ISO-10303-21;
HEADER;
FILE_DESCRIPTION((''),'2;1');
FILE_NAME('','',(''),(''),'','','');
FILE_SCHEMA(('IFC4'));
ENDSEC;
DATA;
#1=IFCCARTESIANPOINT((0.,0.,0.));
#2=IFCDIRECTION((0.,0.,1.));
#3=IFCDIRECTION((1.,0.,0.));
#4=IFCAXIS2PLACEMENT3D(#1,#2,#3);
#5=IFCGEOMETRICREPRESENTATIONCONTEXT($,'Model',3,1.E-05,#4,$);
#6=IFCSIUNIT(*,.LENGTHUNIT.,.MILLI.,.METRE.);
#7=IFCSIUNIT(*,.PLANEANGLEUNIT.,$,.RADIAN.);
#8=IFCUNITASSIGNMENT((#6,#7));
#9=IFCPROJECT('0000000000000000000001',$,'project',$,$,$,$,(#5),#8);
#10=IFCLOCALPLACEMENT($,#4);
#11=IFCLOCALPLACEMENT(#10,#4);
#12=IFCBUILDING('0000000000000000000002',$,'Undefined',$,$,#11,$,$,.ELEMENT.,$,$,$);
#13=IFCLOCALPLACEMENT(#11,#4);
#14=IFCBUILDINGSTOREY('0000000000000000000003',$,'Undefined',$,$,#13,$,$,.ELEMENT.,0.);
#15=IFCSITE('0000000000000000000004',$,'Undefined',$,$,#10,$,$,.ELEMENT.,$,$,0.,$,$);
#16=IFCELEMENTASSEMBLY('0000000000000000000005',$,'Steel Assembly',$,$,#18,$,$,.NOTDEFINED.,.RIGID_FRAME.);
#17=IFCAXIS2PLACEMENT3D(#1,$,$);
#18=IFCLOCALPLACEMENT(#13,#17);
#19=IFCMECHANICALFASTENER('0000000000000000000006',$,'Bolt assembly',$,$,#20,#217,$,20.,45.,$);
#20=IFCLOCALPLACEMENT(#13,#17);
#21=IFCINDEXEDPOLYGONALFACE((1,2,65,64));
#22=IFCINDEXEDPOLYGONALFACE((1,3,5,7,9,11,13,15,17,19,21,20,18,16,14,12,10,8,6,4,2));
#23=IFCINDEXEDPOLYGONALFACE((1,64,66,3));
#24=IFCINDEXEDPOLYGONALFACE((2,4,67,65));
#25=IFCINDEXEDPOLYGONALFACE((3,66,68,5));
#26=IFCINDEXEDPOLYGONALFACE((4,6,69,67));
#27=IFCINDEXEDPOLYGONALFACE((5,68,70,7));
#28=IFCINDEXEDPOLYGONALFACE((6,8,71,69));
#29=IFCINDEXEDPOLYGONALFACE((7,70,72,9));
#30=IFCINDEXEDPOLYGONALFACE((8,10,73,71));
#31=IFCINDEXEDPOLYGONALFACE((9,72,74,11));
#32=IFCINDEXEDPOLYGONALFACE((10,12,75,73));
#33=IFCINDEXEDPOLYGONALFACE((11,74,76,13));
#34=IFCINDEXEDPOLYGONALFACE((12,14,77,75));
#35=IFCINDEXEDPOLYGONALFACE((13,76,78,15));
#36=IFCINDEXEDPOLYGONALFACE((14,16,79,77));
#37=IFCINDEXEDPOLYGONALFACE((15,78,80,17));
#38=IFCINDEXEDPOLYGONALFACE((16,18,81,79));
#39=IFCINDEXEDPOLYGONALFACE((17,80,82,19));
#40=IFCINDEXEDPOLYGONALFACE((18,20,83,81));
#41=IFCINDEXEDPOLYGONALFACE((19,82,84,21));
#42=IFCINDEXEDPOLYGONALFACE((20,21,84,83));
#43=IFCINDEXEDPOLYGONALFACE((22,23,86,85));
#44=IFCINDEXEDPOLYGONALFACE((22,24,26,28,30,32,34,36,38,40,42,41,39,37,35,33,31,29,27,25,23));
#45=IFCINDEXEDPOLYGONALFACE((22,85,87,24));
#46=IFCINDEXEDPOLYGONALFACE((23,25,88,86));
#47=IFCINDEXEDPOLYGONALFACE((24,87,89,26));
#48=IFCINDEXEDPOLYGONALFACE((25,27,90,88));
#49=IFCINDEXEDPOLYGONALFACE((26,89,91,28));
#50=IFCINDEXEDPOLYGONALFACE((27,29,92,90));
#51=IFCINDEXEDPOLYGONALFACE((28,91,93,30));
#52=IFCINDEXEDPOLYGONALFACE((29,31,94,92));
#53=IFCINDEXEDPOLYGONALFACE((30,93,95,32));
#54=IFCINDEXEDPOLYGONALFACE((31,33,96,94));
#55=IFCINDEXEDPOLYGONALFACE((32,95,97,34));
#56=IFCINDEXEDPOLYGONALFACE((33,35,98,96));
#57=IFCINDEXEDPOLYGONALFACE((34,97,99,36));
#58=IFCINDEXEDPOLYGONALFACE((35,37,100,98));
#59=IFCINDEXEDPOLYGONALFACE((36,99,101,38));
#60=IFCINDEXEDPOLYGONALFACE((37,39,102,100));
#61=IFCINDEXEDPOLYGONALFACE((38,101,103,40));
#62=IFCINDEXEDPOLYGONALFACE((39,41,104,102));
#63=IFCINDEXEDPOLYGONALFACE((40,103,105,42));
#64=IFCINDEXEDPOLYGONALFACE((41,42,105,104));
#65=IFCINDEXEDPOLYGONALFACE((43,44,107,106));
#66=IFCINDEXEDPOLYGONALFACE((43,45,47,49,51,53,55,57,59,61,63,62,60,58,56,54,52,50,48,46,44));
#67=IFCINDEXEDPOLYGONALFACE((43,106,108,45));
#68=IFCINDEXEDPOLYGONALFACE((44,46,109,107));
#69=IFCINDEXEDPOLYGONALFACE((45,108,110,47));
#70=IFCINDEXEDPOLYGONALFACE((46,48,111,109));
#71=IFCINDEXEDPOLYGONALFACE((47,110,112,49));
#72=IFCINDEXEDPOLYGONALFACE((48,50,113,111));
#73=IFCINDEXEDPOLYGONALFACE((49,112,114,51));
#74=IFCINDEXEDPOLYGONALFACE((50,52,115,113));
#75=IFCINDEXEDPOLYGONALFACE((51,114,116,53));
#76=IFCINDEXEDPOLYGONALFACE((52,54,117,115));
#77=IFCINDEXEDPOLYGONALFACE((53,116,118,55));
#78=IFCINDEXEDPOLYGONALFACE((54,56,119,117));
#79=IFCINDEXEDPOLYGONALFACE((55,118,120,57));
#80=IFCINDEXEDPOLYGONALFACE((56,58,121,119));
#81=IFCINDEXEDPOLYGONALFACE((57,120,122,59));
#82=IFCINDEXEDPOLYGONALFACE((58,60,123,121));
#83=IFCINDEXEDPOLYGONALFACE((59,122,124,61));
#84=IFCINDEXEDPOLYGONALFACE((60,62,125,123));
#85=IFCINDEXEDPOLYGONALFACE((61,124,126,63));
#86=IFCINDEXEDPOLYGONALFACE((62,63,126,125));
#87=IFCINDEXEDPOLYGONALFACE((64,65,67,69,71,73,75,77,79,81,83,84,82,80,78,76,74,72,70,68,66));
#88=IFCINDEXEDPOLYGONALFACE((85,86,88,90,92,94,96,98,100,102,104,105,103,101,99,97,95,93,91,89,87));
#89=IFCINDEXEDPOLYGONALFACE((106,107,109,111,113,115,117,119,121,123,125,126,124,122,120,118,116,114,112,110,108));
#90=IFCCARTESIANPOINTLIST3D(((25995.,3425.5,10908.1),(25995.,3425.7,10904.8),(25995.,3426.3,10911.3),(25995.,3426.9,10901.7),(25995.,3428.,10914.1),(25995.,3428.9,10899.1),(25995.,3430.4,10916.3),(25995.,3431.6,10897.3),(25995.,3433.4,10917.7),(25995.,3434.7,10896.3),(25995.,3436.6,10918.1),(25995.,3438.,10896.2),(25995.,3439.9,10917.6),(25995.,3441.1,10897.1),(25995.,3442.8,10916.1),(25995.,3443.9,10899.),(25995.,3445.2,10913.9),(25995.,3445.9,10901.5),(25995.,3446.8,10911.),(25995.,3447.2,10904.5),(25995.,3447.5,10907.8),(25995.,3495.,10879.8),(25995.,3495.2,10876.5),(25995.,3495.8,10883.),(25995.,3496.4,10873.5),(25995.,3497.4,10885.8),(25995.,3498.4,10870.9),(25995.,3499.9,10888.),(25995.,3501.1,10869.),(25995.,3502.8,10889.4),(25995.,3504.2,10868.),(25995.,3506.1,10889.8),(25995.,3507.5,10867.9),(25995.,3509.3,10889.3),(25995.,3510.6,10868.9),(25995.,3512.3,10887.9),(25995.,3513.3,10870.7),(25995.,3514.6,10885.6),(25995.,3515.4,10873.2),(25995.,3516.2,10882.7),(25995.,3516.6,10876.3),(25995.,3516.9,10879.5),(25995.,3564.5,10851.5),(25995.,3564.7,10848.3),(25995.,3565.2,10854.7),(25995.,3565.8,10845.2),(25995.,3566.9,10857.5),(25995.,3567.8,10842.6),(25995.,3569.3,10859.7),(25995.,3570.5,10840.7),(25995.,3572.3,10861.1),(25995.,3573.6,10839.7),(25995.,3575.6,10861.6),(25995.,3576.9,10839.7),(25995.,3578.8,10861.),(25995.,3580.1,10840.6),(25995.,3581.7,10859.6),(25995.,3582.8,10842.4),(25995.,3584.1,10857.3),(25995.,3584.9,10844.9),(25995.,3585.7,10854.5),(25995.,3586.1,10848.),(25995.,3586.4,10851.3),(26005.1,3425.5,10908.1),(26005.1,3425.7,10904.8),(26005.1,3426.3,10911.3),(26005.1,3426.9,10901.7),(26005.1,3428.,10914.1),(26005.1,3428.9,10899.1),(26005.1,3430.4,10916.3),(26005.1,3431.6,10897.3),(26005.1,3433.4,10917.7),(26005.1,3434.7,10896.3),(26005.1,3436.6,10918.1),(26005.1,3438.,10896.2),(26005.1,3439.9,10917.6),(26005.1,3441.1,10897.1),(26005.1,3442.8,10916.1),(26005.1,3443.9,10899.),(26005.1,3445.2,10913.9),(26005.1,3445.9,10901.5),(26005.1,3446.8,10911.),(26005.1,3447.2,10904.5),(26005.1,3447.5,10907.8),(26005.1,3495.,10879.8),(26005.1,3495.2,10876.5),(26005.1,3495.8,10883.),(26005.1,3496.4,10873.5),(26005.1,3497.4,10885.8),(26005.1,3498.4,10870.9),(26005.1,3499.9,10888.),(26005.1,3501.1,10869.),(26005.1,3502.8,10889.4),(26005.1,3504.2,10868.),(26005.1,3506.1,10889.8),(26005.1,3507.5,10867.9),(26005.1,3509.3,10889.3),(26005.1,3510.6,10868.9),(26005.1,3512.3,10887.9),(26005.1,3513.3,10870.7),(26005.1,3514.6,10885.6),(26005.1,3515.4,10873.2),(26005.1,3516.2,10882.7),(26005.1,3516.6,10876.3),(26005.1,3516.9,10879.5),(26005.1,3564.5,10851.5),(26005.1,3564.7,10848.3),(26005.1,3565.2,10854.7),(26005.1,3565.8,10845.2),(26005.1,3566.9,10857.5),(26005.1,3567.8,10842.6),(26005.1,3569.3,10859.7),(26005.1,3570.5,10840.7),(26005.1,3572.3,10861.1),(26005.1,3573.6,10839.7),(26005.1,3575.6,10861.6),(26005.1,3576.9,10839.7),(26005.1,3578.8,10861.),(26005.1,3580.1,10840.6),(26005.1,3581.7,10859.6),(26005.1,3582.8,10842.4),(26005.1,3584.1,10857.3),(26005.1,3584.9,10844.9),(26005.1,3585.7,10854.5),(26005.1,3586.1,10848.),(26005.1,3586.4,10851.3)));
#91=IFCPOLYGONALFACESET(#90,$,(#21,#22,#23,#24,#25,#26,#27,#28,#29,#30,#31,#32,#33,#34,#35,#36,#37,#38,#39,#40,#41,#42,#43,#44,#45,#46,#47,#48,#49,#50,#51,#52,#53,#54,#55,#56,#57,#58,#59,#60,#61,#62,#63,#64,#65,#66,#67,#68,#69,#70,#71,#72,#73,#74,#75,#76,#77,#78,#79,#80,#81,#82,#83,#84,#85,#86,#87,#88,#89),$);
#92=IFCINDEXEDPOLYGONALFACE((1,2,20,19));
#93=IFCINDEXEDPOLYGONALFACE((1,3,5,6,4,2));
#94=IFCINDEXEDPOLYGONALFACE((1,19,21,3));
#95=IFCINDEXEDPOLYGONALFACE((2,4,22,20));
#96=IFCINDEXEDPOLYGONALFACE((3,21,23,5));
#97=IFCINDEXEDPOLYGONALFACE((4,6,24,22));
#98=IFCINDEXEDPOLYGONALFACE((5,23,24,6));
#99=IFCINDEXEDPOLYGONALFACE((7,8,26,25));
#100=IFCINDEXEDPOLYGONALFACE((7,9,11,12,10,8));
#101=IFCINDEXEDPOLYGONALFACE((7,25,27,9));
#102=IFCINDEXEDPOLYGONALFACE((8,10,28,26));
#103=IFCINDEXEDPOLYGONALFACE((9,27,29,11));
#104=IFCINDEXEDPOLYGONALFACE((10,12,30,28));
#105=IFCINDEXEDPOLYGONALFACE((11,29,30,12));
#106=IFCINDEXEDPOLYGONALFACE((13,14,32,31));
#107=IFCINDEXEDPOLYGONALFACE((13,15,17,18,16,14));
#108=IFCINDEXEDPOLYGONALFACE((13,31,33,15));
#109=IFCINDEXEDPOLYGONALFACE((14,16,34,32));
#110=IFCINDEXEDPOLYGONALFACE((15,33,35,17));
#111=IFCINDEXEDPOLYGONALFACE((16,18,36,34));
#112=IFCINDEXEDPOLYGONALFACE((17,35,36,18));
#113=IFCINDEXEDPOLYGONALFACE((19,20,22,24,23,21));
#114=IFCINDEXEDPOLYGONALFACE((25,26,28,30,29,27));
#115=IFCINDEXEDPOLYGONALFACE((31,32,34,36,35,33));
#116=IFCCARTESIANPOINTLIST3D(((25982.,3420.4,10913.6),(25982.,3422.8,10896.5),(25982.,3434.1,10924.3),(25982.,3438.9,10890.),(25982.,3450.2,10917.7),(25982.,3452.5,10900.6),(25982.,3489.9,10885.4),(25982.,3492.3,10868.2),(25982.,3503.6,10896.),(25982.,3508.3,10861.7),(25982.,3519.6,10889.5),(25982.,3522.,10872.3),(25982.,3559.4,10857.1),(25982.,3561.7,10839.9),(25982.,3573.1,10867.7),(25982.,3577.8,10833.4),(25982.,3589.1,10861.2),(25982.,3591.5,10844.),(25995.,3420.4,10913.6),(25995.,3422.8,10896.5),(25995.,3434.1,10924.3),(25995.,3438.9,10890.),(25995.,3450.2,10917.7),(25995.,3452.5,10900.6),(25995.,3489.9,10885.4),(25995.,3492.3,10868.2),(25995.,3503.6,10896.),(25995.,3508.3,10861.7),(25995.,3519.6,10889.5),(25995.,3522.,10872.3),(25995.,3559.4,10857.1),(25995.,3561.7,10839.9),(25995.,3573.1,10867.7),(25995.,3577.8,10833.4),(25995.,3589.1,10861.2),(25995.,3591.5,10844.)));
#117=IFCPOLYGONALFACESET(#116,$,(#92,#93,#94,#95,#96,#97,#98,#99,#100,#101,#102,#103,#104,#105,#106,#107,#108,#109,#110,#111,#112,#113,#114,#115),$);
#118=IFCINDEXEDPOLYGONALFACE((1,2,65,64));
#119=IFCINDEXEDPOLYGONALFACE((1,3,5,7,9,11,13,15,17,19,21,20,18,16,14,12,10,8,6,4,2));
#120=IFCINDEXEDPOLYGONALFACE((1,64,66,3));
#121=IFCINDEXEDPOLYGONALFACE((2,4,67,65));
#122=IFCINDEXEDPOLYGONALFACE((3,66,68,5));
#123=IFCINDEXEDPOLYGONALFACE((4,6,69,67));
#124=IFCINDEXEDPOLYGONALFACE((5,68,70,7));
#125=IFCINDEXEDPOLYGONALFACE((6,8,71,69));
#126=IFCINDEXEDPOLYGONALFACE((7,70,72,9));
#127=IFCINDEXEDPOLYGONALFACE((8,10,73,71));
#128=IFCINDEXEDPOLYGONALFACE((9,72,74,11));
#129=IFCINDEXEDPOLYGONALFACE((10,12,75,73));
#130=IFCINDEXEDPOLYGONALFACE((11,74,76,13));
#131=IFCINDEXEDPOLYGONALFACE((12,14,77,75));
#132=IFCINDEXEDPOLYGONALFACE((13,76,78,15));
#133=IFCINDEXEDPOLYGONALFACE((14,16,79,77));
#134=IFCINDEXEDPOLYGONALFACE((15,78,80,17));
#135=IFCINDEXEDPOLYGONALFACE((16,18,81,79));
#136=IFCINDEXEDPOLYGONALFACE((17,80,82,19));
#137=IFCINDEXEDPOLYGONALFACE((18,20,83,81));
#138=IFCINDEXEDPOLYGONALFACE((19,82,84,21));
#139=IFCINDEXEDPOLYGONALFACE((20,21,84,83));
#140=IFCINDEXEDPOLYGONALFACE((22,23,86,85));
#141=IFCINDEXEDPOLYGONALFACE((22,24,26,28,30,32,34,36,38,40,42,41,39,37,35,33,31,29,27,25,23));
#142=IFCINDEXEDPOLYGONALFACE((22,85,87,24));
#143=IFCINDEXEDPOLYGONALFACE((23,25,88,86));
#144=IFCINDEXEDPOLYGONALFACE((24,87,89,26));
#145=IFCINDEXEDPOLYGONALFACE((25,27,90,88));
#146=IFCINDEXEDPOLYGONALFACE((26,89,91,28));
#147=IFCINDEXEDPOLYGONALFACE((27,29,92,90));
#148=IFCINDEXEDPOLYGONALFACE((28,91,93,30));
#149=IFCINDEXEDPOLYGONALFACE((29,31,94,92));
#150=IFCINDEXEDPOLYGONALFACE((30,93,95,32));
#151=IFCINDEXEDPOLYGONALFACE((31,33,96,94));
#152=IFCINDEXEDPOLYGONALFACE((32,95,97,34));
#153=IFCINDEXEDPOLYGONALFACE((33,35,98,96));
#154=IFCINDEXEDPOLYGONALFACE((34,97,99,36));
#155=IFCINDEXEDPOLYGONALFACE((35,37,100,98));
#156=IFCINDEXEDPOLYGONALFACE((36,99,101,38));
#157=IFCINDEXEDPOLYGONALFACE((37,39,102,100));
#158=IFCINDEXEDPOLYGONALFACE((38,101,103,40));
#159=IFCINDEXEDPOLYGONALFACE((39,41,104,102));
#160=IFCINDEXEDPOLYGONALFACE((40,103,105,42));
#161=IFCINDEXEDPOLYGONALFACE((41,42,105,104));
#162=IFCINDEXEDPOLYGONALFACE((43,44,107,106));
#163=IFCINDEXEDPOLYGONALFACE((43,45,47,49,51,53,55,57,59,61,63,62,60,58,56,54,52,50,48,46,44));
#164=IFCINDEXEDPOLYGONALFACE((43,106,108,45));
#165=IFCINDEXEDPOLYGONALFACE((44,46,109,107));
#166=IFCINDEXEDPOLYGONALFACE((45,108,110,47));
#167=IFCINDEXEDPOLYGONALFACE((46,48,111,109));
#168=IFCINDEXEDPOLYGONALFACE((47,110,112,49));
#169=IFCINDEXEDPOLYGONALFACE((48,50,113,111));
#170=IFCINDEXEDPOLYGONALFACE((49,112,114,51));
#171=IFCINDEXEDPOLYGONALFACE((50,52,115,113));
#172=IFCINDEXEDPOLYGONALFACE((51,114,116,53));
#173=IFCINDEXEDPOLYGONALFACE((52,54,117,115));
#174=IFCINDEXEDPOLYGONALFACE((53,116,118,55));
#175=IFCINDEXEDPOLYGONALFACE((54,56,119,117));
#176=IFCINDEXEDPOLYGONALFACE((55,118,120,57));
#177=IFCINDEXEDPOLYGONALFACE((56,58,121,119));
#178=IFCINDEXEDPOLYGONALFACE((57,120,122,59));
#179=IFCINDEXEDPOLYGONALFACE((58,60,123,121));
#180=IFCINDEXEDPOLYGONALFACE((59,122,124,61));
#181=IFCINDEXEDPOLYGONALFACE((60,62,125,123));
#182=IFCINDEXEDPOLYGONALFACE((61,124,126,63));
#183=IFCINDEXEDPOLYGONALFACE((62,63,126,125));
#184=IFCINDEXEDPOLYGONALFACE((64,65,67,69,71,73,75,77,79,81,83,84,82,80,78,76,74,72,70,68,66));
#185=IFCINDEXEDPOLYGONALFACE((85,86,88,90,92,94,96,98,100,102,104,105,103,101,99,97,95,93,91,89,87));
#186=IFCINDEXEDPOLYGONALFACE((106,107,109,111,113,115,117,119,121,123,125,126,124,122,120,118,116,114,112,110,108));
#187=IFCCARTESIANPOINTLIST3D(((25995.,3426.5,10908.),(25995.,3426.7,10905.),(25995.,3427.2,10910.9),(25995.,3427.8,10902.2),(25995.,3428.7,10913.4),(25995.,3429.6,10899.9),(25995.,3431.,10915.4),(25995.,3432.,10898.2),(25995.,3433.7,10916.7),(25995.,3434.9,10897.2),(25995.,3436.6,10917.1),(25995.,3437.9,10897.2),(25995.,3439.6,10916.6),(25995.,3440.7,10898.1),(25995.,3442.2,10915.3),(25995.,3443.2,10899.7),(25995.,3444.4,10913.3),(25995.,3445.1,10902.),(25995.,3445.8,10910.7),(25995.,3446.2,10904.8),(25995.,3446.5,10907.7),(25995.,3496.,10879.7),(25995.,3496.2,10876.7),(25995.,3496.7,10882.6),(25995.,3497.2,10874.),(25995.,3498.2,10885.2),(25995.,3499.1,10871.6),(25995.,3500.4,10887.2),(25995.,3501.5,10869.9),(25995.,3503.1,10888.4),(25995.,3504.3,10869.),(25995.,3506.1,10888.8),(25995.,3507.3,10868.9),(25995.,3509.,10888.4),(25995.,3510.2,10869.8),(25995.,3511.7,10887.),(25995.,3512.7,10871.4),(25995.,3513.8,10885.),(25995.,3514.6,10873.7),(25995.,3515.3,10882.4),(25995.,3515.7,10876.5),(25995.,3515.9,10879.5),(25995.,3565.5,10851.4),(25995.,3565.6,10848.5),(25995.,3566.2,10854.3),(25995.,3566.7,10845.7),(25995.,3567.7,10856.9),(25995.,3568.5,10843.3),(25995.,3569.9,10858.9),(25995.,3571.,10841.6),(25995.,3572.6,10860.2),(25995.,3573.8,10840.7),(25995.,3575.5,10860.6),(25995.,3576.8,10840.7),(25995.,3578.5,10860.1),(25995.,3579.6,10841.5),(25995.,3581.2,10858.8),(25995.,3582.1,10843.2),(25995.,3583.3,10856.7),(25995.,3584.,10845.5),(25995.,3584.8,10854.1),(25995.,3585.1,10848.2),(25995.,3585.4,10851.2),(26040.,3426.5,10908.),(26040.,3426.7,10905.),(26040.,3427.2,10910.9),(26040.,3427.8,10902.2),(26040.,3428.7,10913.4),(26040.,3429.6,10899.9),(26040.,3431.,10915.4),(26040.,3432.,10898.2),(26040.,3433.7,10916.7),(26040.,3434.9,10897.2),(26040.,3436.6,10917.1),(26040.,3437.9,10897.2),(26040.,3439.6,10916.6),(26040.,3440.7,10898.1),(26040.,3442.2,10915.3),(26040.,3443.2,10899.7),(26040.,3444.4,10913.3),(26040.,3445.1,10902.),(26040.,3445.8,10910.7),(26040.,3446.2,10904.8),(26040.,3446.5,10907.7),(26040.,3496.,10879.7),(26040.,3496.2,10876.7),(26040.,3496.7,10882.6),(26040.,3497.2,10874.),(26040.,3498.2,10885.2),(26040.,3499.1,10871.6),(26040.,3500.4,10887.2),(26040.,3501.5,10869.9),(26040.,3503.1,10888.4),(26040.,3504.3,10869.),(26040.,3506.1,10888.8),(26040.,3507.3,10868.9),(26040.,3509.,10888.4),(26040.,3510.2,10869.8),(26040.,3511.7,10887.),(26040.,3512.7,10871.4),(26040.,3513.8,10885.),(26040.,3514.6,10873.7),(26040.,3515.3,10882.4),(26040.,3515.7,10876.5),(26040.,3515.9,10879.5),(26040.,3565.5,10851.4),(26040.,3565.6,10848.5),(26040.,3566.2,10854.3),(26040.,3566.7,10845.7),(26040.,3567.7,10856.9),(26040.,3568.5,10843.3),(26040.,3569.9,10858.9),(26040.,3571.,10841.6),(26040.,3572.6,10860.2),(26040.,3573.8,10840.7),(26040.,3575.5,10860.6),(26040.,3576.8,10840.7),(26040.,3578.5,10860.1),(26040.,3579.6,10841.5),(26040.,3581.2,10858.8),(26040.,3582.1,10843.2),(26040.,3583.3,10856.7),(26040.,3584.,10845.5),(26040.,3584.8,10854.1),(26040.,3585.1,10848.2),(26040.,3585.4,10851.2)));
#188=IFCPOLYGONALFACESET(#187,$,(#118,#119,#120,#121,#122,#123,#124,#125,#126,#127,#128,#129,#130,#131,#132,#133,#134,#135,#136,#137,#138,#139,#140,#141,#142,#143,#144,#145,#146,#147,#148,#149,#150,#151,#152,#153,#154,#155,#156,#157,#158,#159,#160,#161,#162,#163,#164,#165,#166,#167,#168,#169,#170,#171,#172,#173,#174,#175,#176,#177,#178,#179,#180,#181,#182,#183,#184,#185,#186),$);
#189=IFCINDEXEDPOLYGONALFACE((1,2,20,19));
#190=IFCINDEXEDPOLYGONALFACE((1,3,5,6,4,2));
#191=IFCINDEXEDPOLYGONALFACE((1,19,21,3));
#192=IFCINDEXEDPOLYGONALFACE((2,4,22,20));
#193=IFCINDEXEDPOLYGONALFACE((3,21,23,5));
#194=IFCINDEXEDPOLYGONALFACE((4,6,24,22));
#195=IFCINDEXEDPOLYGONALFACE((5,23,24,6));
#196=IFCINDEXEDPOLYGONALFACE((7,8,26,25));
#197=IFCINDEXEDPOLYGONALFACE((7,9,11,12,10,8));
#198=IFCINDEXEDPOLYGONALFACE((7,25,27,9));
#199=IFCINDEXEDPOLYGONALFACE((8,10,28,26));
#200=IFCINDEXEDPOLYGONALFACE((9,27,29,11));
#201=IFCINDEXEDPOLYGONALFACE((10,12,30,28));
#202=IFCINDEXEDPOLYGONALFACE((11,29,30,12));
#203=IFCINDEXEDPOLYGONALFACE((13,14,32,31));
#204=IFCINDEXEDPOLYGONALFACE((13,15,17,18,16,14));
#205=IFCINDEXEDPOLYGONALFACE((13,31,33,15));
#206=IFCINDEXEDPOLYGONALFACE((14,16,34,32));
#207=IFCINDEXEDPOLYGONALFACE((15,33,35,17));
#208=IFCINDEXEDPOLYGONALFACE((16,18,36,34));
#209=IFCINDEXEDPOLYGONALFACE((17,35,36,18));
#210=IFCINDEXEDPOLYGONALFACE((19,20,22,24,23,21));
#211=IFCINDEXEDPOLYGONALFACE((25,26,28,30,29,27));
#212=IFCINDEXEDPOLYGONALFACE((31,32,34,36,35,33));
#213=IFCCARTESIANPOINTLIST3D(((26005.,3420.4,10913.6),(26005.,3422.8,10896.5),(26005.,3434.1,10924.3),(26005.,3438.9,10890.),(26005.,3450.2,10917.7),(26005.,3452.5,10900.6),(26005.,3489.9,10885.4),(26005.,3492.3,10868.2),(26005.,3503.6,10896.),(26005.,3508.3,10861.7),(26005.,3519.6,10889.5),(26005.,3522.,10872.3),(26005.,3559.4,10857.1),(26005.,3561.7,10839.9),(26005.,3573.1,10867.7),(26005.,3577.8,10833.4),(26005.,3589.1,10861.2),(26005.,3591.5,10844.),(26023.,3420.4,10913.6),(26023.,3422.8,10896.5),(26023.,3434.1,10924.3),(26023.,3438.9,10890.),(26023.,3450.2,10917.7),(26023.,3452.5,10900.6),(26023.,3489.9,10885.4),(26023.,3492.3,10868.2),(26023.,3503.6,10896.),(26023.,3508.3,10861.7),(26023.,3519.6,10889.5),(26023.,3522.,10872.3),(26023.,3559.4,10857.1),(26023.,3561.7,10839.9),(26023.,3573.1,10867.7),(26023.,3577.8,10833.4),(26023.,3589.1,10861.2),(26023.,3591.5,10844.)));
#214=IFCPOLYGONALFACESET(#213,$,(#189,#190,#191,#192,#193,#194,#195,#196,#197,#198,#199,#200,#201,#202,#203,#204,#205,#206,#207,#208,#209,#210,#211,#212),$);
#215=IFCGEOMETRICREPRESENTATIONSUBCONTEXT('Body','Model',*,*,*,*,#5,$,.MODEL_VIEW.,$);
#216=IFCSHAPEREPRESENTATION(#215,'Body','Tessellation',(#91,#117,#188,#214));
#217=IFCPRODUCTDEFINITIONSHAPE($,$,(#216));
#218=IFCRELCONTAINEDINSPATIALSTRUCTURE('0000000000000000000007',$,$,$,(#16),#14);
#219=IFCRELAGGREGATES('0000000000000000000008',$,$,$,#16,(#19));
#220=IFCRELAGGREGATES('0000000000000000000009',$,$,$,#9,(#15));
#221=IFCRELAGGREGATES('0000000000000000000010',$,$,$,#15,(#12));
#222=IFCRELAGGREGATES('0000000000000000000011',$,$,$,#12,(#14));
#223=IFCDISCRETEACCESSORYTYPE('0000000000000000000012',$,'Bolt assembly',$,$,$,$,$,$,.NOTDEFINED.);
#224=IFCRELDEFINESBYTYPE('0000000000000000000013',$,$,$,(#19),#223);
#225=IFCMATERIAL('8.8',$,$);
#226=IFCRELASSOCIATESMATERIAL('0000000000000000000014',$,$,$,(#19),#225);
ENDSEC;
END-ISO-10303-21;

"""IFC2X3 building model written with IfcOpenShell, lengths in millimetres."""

from ifc_helpers import new_model, si_unit, frame, origin_with_axes, origin_2d_with_axis, place, context, subcontext, project, spatial, polyline, circle, outline, extrude, source, transform, mapped, material, type_object, element, aggregate, save


model = new_model("IFC2X3")

# Units and contexts
model_context = context("Model", 3, precision=1e-05, world=origin_with_axes())
body_context = subcontext(model_context, "Body", "Model", "MODEL_VIEW")
ifc_project = project(units=[si_unit("LENGTHUNIT", "METRE", prefix="MILLI"), si_unit("PLANEANGLEUNIT", "RADIAN")], contexts=[model_context])

# Site, building, storey
site_placement = place(None, origin_with_axes())
site = spatial("IfcSite", under=ifc_project, at=site_placement, Name="Undefined", CompositionType="ELEMENT", RefElevation=0.0)
building_placement = place(site_placement, origin_with_axes())
building = spatial("IfcBuilding", under=site, at=building_placement, Name="Undefined", CompositionType="ELEMENT")
storey_placement = place(building_placement, origin_with_axes())
storey = spatial("IfcBuildingStorey", under=building, at=storey_placement, Name="Undefined", CompositionType="ELEMENT", Elevation=0.0)

# Shared definitions
ifc_material_1 = material(Name="8.8")
discrete_accessory_type_1 = type_object("IfcDiscreteAccessoryType", Name="Bolt assembly")

# Element assembly
assembly_1_placement = place(storey_placement, origin_with_axes())
assembly_1 = element("IfcElementAssembly", 1, at=assembly_1_placement, inside=storey, Name="Steel Assembly", AssemblyPlace="NOTDEFINED", PredefinedType="RIGID_FRAME")

# Mechanical fastener
shared_shape_1 = source(origin_with_axes(), body_context, "Body", "SweptSolid", [
    extrude(circle(Radius=11.0, at=origin_2d_with_axis()), frame((0.0, -5.0, 0.0), z_axis=(0.0, 1.0, 0.0), x_axis=(1.0, 0.0, 0.0)), (0.0, 0.0, 1.0), 10.1),
    extrude(outline(polyline([(17.3, 0.0), (8.7, 15.0), (-8.7, 15.0), (-17.3, 0.0), (-8.7, -15.0), (8.7, -15.0), (17.3, 0.0)])), frame((0.0, -18.0, 0.0), z_axis=(0.0, 1.0, 0.0), x_axis=(1.0, 0.0, 0.0)), (0.0, 0.0, 1.0), 13.0),
    extrude(circle(Radius=10.0, at=origin_2d_with_axis()), frame((0.0, -5.0, 0.0), z_axis=(0.0, 1.0, 0.0), x_axis=(1.0, 0.0, 0.0)), (0.0, 0.0, 1.0), 45.0),
    extrude(outline(polyline([(17.3, 0.0), (8.7, 15.0), (-8.7, 15.0), (-17.3, 0.0), (-8.7, -15.0), (8.7, -15.0), (17.3, 0.0)])), frame((0.0, 5.0, 0.0), z_axis=(0.0, 1.0, 0.0), x_axis=(1.0, 0.0, 0.0)), (0.0, 0.0, 1.0), 18.0),
])
mechanical_fastener_1_placement = place(assembly_1_placement, frame((26000.0, 3575.4, 10850.6), z_axis=(0.0, 0.376988, 0.926218), x_axis=(0.0, -0.926218, 0.376988)))
mechanical_fastener_1 = element("IfcMechanicalFastener", 2, at=mechanical_fastener_1_placement, type_object=discrete_accessory_type_1, material=ifc_material_1, Name="Bolt assembly", NominalDiameter=20.0, NominalLength=45.0, context=body_context, shape_type="MappedRepresentation", body=[
    mapped(shared_shape_1, transform((0.0, 0.0, 0.0))),
    mapped(shared_shape_1, transform((75.0, 0.0, 0.0))),
    mapped(shared_shape_1, transform((150.0, 0.0, 0.0))),
])
aggregate(assembly_1, [mechanical_fastener_1])

save(model, "model.ifc")
